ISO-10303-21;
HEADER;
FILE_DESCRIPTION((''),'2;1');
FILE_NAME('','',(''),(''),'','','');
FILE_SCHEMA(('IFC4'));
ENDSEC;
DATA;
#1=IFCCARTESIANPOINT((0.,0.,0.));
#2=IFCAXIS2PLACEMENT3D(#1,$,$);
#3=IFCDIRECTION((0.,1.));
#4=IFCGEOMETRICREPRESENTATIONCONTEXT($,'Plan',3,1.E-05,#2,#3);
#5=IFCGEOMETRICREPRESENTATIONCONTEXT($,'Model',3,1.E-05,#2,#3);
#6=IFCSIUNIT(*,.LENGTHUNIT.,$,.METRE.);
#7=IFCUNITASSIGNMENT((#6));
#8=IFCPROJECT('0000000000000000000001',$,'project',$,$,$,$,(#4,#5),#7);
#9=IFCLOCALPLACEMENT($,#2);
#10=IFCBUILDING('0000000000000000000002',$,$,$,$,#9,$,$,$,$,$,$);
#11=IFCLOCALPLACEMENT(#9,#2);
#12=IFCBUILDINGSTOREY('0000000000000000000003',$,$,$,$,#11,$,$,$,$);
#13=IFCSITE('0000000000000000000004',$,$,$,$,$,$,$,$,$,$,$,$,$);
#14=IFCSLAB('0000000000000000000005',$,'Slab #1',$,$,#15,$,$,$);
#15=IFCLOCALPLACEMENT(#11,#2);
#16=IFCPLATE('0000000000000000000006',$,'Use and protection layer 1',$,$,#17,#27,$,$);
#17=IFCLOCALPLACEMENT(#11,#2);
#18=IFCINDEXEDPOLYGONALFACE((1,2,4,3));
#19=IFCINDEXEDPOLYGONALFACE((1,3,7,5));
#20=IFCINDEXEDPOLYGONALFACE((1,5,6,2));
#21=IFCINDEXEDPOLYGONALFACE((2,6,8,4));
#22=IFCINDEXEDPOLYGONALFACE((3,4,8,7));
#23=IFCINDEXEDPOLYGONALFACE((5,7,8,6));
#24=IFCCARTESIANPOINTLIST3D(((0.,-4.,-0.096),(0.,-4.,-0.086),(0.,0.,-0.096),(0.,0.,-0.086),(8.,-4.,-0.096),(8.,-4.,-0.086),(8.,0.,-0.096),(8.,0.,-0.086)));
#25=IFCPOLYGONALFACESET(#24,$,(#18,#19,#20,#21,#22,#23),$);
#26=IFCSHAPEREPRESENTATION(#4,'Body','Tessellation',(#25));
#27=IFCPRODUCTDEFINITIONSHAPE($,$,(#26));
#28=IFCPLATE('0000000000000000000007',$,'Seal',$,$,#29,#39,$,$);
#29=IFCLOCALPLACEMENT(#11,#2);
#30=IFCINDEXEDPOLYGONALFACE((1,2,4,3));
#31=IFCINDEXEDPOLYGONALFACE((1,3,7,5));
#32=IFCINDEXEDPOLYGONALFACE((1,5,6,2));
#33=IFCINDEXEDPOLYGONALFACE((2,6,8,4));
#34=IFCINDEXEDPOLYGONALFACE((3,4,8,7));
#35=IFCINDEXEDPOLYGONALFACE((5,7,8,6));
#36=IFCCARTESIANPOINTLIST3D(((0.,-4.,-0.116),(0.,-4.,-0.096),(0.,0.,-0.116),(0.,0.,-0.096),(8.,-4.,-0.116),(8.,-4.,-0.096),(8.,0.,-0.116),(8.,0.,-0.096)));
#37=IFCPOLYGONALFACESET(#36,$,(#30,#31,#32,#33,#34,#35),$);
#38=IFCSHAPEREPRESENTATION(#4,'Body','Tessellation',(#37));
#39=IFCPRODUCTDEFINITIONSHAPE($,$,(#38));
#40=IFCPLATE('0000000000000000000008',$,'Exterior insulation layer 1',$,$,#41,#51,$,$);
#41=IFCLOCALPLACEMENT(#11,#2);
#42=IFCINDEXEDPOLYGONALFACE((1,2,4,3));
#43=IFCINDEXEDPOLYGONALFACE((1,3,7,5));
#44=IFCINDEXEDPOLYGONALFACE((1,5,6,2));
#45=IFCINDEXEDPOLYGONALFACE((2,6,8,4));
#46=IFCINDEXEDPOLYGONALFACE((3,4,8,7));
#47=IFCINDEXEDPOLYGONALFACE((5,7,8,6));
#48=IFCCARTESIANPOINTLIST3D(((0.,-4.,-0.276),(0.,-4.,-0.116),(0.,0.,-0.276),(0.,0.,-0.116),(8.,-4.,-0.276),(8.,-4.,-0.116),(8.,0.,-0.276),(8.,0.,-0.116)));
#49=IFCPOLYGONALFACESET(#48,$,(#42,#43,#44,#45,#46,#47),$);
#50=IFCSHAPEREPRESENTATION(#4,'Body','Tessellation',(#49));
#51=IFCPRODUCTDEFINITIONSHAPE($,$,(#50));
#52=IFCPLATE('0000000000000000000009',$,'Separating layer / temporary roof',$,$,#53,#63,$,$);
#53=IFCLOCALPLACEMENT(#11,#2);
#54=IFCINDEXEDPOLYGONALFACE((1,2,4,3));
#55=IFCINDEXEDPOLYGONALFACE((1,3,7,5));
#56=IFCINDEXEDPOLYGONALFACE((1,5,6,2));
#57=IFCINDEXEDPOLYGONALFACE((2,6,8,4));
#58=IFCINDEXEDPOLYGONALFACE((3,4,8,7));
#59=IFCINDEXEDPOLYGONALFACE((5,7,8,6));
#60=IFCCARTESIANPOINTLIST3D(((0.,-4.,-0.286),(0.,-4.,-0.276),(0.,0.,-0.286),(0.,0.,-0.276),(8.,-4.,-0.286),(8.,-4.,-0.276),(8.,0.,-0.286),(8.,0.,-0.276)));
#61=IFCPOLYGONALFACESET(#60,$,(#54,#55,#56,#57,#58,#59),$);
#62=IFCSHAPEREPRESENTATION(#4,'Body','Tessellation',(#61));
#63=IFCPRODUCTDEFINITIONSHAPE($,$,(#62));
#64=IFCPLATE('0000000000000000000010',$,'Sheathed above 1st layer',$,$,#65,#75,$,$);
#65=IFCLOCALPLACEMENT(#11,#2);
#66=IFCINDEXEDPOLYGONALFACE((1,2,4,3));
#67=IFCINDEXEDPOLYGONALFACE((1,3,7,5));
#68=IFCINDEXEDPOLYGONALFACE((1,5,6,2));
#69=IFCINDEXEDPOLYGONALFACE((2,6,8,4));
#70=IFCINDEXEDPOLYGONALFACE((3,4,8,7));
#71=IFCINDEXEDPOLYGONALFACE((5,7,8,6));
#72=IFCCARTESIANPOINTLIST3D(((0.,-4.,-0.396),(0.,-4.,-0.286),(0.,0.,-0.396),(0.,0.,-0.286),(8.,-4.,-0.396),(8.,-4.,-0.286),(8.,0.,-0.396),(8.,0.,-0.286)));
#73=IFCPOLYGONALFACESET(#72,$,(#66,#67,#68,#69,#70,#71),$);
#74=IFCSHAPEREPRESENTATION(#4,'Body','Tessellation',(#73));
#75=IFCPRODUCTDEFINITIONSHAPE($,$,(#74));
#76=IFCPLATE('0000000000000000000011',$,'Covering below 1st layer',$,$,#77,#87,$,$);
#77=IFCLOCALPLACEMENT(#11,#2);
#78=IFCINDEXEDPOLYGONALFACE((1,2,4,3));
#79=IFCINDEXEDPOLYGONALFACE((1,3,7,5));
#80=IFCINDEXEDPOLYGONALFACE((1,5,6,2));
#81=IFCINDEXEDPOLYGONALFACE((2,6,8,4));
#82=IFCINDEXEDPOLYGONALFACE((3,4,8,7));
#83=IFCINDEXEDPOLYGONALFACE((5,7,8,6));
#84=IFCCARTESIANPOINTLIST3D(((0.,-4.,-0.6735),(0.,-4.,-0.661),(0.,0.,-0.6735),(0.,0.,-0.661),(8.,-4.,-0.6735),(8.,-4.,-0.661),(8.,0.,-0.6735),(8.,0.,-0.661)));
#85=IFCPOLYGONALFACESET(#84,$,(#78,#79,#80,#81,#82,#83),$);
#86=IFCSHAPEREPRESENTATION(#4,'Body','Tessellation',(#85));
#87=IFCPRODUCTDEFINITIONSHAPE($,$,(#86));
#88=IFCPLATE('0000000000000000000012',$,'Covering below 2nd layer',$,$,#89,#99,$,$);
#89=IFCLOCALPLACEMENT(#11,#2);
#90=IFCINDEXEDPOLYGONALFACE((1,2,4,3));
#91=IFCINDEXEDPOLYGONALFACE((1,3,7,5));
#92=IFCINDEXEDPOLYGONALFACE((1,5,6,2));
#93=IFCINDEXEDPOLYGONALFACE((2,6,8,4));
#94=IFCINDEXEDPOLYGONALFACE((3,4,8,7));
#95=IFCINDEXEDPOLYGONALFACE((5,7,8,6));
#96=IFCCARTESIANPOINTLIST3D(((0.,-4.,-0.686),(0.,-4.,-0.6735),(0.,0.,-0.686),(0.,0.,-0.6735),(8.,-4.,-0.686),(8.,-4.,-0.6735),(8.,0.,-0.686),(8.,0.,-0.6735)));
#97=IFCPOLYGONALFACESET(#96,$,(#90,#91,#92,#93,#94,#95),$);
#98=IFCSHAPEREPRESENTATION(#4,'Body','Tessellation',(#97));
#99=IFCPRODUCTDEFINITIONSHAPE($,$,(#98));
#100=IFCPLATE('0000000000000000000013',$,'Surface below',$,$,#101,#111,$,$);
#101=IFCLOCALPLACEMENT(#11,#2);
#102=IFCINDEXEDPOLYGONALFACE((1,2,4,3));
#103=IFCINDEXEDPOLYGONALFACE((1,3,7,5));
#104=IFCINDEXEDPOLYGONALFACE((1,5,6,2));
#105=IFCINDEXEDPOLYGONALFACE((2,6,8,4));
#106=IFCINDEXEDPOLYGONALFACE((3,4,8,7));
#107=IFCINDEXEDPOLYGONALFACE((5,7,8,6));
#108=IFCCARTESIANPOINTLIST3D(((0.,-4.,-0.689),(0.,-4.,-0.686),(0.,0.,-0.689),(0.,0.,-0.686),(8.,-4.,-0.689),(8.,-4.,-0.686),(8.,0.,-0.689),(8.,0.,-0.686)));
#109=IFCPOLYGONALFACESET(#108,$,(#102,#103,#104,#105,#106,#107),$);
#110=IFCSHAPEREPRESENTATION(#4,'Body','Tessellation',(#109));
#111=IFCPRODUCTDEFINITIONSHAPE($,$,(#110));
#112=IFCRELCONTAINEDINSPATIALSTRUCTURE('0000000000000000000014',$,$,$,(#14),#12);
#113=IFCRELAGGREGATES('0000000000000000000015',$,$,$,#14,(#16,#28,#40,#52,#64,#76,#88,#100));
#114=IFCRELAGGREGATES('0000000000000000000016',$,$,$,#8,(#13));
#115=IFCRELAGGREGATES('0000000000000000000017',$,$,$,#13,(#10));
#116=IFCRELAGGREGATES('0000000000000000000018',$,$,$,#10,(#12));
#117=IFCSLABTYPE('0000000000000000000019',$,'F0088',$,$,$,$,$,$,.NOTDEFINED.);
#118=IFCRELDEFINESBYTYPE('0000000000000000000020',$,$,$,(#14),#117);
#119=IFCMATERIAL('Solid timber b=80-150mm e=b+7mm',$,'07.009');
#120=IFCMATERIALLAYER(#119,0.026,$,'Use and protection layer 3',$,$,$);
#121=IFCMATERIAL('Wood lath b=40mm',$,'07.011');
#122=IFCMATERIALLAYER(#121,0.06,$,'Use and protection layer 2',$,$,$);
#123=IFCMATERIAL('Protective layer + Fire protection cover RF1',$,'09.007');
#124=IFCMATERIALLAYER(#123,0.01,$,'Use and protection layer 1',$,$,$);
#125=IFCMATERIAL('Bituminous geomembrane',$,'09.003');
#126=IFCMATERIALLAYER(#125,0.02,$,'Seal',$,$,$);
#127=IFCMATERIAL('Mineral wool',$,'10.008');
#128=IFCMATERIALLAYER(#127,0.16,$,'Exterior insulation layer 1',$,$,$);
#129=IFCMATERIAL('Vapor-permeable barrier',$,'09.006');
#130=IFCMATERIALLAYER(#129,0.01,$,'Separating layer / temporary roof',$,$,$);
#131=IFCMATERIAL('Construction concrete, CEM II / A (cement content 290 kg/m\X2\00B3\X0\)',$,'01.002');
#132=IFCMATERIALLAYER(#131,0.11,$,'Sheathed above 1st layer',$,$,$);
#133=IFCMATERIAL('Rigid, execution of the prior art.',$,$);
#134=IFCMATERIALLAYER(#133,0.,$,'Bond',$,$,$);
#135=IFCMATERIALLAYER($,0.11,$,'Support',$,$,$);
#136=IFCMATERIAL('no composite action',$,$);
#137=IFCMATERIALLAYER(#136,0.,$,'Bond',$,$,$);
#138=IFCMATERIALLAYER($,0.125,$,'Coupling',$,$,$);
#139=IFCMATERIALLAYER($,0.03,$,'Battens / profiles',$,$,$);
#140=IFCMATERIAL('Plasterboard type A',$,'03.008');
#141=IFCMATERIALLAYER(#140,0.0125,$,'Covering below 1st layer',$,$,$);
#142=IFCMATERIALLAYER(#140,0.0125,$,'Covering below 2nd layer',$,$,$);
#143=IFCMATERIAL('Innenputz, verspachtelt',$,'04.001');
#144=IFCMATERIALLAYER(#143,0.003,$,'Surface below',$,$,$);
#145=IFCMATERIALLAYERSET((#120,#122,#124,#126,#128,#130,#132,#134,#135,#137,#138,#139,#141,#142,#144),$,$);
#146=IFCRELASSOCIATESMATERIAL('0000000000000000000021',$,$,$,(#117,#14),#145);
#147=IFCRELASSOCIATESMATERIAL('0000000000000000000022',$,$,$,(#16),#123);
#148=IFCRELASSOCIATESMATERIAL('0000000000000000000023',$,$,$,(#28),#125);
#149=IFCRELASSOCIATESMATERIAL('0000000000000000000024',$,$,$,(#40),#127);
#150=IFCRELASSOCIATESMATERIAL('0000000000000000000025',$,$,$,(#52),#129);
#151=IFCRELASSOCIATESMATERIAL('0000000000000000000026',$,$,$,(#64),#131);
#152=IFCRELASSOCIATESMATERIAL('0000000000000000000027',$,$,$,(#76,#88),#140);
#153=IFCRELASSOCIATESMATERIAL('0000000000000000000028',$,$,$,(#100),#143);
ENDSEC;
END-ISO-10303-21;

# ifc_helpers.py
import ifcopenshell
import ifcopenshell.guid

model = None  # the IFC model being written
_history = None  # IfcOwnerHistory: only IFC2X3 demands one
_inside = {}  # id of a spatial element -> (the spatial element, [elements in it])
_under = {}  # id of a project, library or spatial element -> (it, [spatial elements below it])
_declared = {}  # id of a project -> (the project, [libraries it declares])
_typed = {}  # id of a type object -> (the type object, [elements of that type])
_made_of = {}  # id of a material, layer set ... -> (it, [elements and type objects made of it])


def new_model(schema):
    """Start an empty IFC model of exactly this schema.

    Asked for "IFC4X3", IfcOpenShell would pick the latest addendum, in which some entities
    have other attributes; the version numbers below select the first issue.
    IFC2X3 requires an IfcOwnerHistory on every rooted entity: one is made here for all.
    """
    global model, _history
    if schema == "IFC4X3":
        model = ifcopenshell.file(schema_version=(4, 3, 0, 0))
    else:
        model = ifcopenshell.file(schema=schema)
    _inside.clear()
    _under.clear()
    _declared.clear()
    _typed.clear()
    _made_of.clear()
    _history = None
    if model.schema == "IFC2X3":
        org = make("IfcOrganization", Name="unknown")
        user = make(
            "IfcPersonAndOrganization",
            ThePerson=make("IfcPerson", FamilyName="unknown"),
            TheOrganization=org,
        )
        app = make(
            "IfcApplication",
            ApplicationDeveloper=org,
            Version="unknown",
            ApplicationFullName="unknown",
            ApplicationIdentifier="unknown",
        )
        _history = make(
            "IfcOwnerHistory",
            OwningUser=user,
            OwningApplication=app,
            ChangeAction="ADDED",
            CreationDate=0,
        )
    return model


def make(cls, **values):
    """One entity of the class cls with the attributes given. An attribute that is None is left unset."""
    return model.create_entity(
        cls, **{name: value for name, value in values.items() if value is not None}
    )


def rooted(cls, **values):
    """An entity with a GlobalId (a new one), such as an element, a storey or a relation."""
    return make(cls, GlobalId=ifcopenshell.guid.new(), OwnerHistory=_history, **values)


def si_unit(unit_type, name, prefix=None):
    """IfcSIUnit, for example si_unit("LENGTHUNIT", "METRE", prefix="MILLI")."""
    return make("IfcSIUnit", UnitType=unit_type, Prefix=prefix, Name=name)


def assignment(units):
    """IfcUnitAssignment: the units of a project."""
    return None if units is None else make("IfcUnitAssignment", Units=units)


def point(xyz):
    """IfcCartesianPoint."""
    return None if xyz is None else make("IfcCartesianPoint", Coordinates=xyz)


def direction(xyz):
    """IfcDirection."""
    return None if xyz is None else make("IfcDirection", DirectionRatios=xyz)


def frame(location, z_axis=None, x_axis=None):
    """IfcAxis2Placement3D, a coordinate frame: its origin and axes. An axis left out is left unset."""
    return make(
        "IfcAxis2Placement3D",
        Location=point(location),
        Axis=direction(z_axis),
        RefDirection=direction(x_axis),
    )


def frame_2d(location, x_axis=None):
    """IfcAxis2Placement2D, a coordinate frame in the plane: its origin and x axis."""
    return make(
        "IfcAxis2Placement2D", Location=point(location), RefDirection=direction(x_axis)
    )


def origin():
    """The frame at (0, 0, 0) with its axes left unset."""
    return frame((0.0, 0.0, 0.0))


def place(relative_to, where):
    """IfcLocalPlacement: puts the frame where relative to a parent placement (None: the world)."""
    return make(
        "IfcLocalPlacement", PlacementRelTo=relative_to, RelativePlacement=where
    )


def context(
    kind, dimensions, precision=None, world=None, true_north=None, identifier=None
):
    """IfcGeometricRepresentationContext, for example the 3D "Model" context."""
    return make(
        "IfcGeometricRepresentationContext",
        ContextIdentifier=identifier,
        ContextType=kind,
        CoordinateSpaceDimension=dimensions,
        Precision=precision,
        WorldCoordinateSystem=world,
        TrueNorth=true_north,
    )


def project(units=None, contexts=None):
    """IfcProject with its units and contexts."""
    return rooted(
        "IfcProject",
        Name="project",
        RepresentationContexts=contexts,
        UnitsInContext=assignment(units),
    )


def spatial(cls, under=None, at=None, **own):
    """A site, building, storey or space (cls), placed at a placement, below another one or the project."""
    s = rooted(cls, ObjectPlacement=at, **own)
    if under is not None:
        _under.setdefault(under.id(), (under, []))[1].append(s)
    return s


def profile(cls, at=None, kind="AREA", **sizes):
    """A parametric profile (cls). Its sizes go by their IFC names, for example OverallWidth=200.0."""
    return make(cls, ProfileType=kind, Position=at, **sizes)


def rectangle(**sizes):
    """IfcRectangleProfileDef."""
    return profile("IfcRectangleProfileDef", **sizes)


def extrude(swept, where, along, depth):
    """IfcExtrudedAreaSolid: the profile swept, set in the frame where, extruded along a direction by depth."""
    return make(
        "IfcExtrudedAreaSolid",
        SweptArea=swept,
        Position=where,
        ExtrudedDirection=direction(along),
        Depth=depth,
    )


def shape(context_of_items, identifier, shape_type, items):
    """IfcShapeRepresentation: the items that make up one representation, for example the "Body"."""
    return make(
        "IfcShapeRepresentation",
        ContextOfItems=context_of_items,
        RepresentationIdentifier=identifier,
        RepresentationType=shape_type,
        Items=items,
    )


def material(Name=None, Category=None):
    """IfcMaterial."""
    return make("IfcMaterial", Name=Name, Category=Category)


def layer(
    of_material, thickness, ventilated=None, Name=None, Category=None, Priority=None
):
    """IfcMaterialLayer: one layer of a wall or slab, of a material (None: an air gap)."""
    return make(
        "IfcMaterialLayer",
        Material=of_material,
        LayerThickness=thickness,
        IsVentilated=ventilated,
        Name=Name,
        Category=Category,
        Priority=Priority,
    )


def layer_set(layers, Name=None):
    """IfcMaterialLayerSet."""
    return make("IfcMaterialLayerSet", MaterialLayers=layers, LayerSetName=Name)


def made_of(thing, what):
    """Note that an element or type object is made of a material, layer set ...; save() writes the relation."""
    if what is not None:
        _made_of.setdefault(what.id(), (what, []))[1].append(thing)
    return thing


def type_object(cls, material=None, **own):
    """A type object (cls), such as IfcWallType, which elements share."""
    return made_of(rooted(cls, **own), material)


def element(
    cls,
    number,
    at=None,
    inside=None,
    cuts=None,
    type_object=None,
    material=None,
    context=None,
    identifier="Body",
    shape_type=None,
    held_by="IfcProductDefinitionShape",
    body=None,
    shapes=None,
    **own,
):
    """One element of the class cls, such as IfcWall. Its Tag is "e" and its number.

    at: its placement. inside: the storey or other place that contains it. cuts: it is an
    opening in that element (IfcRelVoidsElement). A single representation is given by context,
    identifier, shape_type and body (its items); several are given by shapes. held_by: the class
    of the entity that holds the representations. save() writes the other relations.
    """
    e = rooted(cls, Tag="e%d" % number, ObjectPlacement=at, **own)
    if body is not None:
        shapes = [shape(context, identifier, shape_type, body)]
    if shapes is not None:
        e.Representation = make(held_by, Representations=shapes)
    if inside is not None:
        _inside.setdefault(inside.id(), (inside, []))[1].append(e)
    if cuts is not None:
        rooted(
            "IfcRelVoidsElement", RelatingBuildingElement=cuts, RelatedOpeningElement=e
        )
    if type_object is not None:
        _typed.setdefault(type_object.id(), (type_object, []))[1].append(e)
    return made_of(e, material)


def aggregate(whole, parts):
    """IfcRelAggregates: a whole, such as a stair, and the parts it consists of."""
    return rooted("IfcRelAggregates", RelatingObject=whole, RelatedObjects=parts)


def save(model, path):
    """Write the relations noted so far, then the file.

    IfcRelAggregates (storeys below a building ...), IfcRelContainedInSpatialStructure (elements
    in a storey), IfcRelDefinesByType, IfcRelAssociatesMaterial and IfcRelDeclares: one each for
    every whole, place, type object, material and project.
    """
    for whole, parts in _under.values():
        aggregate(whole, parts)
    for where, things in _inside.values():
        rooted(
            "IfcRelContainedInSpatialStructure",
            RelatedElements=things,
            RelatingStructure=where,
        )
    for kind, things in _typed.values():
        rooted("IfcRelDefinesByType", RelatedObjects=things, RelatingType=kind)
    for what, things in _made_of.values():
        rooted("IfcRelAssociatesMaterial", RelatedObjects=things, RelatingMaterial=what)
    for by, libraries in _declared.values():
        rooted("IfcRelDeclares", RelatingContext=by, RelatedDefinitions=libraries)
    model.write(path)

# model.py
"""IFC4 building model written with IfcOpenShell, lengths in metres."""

from ifc_helpers import new_model, si_unit, direction, frame, frame_2d, origin, place, context, project, spatial, rectangle, extrude, material, layer, layer_set, type_object, element, aggregate, save


model = new_model("IFC4")

# Units and contexts
plan_context = context("Plan", 3, precision=1e-05, world=origin(), true_north=direction((0.0, 1.0)))
model_context = context("Model", 3, precision=1e-05, world=origin(), true_north=direction((0.0, 1.0)))
ifc_project = project(units=[si_unit("LENGTHUNIT", "METRE")], contexts=[plan_context, model_context])

# Site, building, storey
site = spatial("IfcSite", under=ifc_project)
building_placement = place(None, origin())
building = spatial("IfcBuilding", under=site, at=building_placement)
storey_placement = place(building_placement, origin())
storey = spatial("IfcBuildingStorey", under=building, at=storey_placement)

# Slab, plates
ifc_material_1 = material(Name="Solid timber b=80-150mm e=b+7mm", Category="07.009")
ifc_layer_1 = layer(ifc_material_1, 0.026, Name="Use and protection layer 3")
ifc_material_2 = material(Name="Wood lath b=40mm", Category="07.011")
ifc_layer_2 = layer(ifc_material_2, 0.06, Name="Use and protection layer 2")
ifc_material_3 = material(Name="Protective layer + Fire protection cover RF1", Category="09.007")
ifc_layer_3 = layer(ifc_material_3, 0.01, Name="Use and protection layer 1")
ifc_material_4 = material(Name="Bituminous geomembrane", Category="09.003")
ifc_layer_4 = layer(ifc_material_4, 0.02, Name="Seal")
ifc_material_5 = material(Name="Mineral wool", Category="10.008")
ifc_layer_5 = layer(ifc_material_5, 0.16, Name="Exterior insulation layer 1")
ifc_material_6 = material(Name="Vapor-permeable barrier", Category="09.006")
ifc_layer_6 = layer(ifc_material_6, 0.01, Name="Separating layer / temporary roof")
ifc_material_7 = material(Name="Construction concrete, CEM II / A (cement content 290 kg/m³)", Category="01.002")
ifc_layer_7 = layer(ifc_material_7, 0.11, Name="Sheathed above 1st layer")
ifc_material_8 = material(Name="Rigid, execution of the prior art.")
ifc_layer_8 = layer(ifc_material_8, 0.0, Name="Bond")
ifc_layer_9 = layer(None, 0.11, Name="Support")
ifc_material_9 = material(Name="no composite action")
ifc_layer_10 = layer(ifc_material_9, 0.0, Name="Bond")
ifc_layer_11 = layer(None, 0.125, Name="Coupling")
ifc_layer_12 = layer(None, 0.03, Name="Battens / profiles")
ifc_material_10 = material(Name="Plasterboard type A", Category="03.008")
ifc_layer_13 = layer(ifc_material_10, 0.0125, Name="Covering below 1st layer")
ifc_layer_14 = layer(ifc_material_10, 0.0125, Name="Covering below 2nd layer")
ifc_material_11 = material(Name="Innenputz, verspachtelt", Category="04.001")
ifc_layer_15 = layer(ifc_material_11, 0.003, Name="Surface below")
ifc_layer_set = layer_set([ifc_layer_1, ifc_layer_2, ifc_layer_3, ifc_layer_4, ifc_layer_5, ifc_layer_6, ifc_layer_7, ifc_layer_8, ifc_layer_9, ifc_layer_10, ifc_layer_11, ifc_layer_12, ifc_layer_13, ifc_layer_14, ifc_layer_15])
slab_type = type_object("IfcSlabType", Name="F0088", PredefinedType="NOTDEFINED", material=ifc_layer_set)
slab_placement = place(None, frame((0.0, 0.0, 0.0), z_axis=(0.0, 0.0, -1.0), x_axis=(1.0, 0.0, 0.0)))
slab = element("IfcSlab", 1, at=slab_placement, inside=storey, type_object=slab_type, material=ifc_layer_set, Name="Slab #1")
plate_1_placement = place(slab_placement, origin())
plate_1 = element("IfcPlate", 2, at=plate_1_placement, material=ifc_material_3, Name="Use and protection layer 1", context=plan_context, shape_type="SweptSolid", body=[
    extrude(rectangle(XDim=8.0, YDim=4.0, at=frame_2d((4.0, 2.0), x_axis=(1.0, 0.0))), frame((0.0, 0.0, 0.086), z_axis=(0.0, 0.0, 1.0), x_axis=(1.0, 0.0, 0.0)), (0.0, 0.0, 1.0), 0.01),
])
plate_2_placement = place(slab_placement, origin())
plate_2 = element("IfcPlate", 3, at=plate_2_placement, material=ifc_material_4, Name="Seal", context=plan_context, shape_type="SweptSolid", body=[
    extrude(rectangle(XDim=8.0, YDim=4.0, at=frame_2d((4.0, 2.0), x_axis=(1.0, 0.0))), frame((0.0, 0.0, 0.096), z_axis=(0.0, 0.0, 1.0), x_axis=(1.0, 0.0, 0.0)), (0.0, 0.0, 1.0), 0.02),
])
plate_3_placement = place(slab_placement, origin())
plate_3 = element("IfcPlate", 4, at=plate_3_placement, material=ifc_material_5, Name="Exterior insulation layer 1", context=plan_context, shape_type="SweptSolid", body=[
    extrude(rectangle(XDim=8.0, YDim=4.0, at=frame_2d((4.0, 2.0), x_axis=(1.0, 0.0))), frame((0.0, 0.0, 0.116), z_axis=(0.0, 0.0, 1.0), x_axis=(1.0, 0.0, 0.0)), (0.0, 0.0, 1.0), 0.16),
])
plate_4_placement = place(slab_placement, origin())
plate_4 = element("IfcPlate", 5, at=plate_4_placement, material=ifc_material_6, Name="Separating layer / temporary roof", context=plan_context, shape_type="SweptSolid", body=[
    extrude(rectangle(XDim=8.0, YDim=4.0, at=frame_2d((4.0, 2.0), x_axis=(1.0, 0.0))), frame((0.0, 0.0, 0.276), z_axis=(0.0, 0.0, 1.0), x_axis=(1.0, 0.0, 0.0)), (0.0, 0.0, 1.0), 0.01),
])
plate_5_placement = place(slab_placement, origin())
plate_5 = element("IfcPlate", 6, at=plate_5_placement, material=ifc_material_7, Name="Sheathed above 1st layer", context=plan_context, shape_type="SweptSolid", body=[
    extrude(rectangle(XDim=8.0, YDim=4.0, at=frame_2d((4.0, 2.0), x_axis=(1.0, 0.0))), frame((0.0, 0.0, 0.286), z_axis=(0.0, 0.0, 1.0), x_axis=(1.0, 0.0, 0.0)), (0.0, 0.0, 1.0), 0.11),
])
plate_6_placement = place(slab_placement, origin())
plate_6 = element("IfcPlate", 7, at=plate_6_placement, material=ifc_material_10, Name="Covering below 1st layer", context=plan_context, shape_type="SweptSolid", body=[
    extrude(rectangle(XDim=8.0, YDim=4.0, at=frame_2d((4.0, 2.0), x_axis=(1.0, 0.0))), frame((0.0, 0.0, 0.661), z_axis=(0.0, 0.0, 1.0), x_axis=(1.0, 0.0, 0.0)), (0.0, 0.0, 1.0), 0.0125),
])
plate_7_placement = place(slab_placement, origin())
plate_7 = element("IfcPlate", 8, at=plate_7_placement, material=ifc_material_10, Name="Covering below 2nd layer", context=plan_context, shape_type="SweptSolid", body=[
    extrude(rectangle(XDim=8.0, YDim=4.0, at=frame_2d((4.0, 2.0), x_axis=(1.0, 0.0))), frame((0.0, 0.0, 0.6735), z_axis=(0.0, 0.0, 1.0), x_axis=(1.0, 0.0, 0.0)), (0.0, 0.0, 1.0), 0.0125),
])
plate_8_placement = place(slab_placement, origin())
plate_8 = element("IfcPlate", 9, at=plate_8_placement, material=ifc_material_11, Name="Surface below", context=plan_context, shape_type="SweptSolid", body=[
    extrude(rectangle(XDim=8.0, YDim=4.0, at=frame_2d((4.0, 2.0), x_axis=(1.0, 0.0))), frame((0.0, 0.0, 0.686), z_axis=(0.0, 0.0, 1.0), x_axis=(1.0, 0.0, 0.0)), (0.0, 0.0, 1.0), 0.003),
])
aggregate(slab, [plate_1, plate_2, plate_3, plate_4, plate_5, plate_6, plate_7, plate_8])

save(model, "model.ifc")
